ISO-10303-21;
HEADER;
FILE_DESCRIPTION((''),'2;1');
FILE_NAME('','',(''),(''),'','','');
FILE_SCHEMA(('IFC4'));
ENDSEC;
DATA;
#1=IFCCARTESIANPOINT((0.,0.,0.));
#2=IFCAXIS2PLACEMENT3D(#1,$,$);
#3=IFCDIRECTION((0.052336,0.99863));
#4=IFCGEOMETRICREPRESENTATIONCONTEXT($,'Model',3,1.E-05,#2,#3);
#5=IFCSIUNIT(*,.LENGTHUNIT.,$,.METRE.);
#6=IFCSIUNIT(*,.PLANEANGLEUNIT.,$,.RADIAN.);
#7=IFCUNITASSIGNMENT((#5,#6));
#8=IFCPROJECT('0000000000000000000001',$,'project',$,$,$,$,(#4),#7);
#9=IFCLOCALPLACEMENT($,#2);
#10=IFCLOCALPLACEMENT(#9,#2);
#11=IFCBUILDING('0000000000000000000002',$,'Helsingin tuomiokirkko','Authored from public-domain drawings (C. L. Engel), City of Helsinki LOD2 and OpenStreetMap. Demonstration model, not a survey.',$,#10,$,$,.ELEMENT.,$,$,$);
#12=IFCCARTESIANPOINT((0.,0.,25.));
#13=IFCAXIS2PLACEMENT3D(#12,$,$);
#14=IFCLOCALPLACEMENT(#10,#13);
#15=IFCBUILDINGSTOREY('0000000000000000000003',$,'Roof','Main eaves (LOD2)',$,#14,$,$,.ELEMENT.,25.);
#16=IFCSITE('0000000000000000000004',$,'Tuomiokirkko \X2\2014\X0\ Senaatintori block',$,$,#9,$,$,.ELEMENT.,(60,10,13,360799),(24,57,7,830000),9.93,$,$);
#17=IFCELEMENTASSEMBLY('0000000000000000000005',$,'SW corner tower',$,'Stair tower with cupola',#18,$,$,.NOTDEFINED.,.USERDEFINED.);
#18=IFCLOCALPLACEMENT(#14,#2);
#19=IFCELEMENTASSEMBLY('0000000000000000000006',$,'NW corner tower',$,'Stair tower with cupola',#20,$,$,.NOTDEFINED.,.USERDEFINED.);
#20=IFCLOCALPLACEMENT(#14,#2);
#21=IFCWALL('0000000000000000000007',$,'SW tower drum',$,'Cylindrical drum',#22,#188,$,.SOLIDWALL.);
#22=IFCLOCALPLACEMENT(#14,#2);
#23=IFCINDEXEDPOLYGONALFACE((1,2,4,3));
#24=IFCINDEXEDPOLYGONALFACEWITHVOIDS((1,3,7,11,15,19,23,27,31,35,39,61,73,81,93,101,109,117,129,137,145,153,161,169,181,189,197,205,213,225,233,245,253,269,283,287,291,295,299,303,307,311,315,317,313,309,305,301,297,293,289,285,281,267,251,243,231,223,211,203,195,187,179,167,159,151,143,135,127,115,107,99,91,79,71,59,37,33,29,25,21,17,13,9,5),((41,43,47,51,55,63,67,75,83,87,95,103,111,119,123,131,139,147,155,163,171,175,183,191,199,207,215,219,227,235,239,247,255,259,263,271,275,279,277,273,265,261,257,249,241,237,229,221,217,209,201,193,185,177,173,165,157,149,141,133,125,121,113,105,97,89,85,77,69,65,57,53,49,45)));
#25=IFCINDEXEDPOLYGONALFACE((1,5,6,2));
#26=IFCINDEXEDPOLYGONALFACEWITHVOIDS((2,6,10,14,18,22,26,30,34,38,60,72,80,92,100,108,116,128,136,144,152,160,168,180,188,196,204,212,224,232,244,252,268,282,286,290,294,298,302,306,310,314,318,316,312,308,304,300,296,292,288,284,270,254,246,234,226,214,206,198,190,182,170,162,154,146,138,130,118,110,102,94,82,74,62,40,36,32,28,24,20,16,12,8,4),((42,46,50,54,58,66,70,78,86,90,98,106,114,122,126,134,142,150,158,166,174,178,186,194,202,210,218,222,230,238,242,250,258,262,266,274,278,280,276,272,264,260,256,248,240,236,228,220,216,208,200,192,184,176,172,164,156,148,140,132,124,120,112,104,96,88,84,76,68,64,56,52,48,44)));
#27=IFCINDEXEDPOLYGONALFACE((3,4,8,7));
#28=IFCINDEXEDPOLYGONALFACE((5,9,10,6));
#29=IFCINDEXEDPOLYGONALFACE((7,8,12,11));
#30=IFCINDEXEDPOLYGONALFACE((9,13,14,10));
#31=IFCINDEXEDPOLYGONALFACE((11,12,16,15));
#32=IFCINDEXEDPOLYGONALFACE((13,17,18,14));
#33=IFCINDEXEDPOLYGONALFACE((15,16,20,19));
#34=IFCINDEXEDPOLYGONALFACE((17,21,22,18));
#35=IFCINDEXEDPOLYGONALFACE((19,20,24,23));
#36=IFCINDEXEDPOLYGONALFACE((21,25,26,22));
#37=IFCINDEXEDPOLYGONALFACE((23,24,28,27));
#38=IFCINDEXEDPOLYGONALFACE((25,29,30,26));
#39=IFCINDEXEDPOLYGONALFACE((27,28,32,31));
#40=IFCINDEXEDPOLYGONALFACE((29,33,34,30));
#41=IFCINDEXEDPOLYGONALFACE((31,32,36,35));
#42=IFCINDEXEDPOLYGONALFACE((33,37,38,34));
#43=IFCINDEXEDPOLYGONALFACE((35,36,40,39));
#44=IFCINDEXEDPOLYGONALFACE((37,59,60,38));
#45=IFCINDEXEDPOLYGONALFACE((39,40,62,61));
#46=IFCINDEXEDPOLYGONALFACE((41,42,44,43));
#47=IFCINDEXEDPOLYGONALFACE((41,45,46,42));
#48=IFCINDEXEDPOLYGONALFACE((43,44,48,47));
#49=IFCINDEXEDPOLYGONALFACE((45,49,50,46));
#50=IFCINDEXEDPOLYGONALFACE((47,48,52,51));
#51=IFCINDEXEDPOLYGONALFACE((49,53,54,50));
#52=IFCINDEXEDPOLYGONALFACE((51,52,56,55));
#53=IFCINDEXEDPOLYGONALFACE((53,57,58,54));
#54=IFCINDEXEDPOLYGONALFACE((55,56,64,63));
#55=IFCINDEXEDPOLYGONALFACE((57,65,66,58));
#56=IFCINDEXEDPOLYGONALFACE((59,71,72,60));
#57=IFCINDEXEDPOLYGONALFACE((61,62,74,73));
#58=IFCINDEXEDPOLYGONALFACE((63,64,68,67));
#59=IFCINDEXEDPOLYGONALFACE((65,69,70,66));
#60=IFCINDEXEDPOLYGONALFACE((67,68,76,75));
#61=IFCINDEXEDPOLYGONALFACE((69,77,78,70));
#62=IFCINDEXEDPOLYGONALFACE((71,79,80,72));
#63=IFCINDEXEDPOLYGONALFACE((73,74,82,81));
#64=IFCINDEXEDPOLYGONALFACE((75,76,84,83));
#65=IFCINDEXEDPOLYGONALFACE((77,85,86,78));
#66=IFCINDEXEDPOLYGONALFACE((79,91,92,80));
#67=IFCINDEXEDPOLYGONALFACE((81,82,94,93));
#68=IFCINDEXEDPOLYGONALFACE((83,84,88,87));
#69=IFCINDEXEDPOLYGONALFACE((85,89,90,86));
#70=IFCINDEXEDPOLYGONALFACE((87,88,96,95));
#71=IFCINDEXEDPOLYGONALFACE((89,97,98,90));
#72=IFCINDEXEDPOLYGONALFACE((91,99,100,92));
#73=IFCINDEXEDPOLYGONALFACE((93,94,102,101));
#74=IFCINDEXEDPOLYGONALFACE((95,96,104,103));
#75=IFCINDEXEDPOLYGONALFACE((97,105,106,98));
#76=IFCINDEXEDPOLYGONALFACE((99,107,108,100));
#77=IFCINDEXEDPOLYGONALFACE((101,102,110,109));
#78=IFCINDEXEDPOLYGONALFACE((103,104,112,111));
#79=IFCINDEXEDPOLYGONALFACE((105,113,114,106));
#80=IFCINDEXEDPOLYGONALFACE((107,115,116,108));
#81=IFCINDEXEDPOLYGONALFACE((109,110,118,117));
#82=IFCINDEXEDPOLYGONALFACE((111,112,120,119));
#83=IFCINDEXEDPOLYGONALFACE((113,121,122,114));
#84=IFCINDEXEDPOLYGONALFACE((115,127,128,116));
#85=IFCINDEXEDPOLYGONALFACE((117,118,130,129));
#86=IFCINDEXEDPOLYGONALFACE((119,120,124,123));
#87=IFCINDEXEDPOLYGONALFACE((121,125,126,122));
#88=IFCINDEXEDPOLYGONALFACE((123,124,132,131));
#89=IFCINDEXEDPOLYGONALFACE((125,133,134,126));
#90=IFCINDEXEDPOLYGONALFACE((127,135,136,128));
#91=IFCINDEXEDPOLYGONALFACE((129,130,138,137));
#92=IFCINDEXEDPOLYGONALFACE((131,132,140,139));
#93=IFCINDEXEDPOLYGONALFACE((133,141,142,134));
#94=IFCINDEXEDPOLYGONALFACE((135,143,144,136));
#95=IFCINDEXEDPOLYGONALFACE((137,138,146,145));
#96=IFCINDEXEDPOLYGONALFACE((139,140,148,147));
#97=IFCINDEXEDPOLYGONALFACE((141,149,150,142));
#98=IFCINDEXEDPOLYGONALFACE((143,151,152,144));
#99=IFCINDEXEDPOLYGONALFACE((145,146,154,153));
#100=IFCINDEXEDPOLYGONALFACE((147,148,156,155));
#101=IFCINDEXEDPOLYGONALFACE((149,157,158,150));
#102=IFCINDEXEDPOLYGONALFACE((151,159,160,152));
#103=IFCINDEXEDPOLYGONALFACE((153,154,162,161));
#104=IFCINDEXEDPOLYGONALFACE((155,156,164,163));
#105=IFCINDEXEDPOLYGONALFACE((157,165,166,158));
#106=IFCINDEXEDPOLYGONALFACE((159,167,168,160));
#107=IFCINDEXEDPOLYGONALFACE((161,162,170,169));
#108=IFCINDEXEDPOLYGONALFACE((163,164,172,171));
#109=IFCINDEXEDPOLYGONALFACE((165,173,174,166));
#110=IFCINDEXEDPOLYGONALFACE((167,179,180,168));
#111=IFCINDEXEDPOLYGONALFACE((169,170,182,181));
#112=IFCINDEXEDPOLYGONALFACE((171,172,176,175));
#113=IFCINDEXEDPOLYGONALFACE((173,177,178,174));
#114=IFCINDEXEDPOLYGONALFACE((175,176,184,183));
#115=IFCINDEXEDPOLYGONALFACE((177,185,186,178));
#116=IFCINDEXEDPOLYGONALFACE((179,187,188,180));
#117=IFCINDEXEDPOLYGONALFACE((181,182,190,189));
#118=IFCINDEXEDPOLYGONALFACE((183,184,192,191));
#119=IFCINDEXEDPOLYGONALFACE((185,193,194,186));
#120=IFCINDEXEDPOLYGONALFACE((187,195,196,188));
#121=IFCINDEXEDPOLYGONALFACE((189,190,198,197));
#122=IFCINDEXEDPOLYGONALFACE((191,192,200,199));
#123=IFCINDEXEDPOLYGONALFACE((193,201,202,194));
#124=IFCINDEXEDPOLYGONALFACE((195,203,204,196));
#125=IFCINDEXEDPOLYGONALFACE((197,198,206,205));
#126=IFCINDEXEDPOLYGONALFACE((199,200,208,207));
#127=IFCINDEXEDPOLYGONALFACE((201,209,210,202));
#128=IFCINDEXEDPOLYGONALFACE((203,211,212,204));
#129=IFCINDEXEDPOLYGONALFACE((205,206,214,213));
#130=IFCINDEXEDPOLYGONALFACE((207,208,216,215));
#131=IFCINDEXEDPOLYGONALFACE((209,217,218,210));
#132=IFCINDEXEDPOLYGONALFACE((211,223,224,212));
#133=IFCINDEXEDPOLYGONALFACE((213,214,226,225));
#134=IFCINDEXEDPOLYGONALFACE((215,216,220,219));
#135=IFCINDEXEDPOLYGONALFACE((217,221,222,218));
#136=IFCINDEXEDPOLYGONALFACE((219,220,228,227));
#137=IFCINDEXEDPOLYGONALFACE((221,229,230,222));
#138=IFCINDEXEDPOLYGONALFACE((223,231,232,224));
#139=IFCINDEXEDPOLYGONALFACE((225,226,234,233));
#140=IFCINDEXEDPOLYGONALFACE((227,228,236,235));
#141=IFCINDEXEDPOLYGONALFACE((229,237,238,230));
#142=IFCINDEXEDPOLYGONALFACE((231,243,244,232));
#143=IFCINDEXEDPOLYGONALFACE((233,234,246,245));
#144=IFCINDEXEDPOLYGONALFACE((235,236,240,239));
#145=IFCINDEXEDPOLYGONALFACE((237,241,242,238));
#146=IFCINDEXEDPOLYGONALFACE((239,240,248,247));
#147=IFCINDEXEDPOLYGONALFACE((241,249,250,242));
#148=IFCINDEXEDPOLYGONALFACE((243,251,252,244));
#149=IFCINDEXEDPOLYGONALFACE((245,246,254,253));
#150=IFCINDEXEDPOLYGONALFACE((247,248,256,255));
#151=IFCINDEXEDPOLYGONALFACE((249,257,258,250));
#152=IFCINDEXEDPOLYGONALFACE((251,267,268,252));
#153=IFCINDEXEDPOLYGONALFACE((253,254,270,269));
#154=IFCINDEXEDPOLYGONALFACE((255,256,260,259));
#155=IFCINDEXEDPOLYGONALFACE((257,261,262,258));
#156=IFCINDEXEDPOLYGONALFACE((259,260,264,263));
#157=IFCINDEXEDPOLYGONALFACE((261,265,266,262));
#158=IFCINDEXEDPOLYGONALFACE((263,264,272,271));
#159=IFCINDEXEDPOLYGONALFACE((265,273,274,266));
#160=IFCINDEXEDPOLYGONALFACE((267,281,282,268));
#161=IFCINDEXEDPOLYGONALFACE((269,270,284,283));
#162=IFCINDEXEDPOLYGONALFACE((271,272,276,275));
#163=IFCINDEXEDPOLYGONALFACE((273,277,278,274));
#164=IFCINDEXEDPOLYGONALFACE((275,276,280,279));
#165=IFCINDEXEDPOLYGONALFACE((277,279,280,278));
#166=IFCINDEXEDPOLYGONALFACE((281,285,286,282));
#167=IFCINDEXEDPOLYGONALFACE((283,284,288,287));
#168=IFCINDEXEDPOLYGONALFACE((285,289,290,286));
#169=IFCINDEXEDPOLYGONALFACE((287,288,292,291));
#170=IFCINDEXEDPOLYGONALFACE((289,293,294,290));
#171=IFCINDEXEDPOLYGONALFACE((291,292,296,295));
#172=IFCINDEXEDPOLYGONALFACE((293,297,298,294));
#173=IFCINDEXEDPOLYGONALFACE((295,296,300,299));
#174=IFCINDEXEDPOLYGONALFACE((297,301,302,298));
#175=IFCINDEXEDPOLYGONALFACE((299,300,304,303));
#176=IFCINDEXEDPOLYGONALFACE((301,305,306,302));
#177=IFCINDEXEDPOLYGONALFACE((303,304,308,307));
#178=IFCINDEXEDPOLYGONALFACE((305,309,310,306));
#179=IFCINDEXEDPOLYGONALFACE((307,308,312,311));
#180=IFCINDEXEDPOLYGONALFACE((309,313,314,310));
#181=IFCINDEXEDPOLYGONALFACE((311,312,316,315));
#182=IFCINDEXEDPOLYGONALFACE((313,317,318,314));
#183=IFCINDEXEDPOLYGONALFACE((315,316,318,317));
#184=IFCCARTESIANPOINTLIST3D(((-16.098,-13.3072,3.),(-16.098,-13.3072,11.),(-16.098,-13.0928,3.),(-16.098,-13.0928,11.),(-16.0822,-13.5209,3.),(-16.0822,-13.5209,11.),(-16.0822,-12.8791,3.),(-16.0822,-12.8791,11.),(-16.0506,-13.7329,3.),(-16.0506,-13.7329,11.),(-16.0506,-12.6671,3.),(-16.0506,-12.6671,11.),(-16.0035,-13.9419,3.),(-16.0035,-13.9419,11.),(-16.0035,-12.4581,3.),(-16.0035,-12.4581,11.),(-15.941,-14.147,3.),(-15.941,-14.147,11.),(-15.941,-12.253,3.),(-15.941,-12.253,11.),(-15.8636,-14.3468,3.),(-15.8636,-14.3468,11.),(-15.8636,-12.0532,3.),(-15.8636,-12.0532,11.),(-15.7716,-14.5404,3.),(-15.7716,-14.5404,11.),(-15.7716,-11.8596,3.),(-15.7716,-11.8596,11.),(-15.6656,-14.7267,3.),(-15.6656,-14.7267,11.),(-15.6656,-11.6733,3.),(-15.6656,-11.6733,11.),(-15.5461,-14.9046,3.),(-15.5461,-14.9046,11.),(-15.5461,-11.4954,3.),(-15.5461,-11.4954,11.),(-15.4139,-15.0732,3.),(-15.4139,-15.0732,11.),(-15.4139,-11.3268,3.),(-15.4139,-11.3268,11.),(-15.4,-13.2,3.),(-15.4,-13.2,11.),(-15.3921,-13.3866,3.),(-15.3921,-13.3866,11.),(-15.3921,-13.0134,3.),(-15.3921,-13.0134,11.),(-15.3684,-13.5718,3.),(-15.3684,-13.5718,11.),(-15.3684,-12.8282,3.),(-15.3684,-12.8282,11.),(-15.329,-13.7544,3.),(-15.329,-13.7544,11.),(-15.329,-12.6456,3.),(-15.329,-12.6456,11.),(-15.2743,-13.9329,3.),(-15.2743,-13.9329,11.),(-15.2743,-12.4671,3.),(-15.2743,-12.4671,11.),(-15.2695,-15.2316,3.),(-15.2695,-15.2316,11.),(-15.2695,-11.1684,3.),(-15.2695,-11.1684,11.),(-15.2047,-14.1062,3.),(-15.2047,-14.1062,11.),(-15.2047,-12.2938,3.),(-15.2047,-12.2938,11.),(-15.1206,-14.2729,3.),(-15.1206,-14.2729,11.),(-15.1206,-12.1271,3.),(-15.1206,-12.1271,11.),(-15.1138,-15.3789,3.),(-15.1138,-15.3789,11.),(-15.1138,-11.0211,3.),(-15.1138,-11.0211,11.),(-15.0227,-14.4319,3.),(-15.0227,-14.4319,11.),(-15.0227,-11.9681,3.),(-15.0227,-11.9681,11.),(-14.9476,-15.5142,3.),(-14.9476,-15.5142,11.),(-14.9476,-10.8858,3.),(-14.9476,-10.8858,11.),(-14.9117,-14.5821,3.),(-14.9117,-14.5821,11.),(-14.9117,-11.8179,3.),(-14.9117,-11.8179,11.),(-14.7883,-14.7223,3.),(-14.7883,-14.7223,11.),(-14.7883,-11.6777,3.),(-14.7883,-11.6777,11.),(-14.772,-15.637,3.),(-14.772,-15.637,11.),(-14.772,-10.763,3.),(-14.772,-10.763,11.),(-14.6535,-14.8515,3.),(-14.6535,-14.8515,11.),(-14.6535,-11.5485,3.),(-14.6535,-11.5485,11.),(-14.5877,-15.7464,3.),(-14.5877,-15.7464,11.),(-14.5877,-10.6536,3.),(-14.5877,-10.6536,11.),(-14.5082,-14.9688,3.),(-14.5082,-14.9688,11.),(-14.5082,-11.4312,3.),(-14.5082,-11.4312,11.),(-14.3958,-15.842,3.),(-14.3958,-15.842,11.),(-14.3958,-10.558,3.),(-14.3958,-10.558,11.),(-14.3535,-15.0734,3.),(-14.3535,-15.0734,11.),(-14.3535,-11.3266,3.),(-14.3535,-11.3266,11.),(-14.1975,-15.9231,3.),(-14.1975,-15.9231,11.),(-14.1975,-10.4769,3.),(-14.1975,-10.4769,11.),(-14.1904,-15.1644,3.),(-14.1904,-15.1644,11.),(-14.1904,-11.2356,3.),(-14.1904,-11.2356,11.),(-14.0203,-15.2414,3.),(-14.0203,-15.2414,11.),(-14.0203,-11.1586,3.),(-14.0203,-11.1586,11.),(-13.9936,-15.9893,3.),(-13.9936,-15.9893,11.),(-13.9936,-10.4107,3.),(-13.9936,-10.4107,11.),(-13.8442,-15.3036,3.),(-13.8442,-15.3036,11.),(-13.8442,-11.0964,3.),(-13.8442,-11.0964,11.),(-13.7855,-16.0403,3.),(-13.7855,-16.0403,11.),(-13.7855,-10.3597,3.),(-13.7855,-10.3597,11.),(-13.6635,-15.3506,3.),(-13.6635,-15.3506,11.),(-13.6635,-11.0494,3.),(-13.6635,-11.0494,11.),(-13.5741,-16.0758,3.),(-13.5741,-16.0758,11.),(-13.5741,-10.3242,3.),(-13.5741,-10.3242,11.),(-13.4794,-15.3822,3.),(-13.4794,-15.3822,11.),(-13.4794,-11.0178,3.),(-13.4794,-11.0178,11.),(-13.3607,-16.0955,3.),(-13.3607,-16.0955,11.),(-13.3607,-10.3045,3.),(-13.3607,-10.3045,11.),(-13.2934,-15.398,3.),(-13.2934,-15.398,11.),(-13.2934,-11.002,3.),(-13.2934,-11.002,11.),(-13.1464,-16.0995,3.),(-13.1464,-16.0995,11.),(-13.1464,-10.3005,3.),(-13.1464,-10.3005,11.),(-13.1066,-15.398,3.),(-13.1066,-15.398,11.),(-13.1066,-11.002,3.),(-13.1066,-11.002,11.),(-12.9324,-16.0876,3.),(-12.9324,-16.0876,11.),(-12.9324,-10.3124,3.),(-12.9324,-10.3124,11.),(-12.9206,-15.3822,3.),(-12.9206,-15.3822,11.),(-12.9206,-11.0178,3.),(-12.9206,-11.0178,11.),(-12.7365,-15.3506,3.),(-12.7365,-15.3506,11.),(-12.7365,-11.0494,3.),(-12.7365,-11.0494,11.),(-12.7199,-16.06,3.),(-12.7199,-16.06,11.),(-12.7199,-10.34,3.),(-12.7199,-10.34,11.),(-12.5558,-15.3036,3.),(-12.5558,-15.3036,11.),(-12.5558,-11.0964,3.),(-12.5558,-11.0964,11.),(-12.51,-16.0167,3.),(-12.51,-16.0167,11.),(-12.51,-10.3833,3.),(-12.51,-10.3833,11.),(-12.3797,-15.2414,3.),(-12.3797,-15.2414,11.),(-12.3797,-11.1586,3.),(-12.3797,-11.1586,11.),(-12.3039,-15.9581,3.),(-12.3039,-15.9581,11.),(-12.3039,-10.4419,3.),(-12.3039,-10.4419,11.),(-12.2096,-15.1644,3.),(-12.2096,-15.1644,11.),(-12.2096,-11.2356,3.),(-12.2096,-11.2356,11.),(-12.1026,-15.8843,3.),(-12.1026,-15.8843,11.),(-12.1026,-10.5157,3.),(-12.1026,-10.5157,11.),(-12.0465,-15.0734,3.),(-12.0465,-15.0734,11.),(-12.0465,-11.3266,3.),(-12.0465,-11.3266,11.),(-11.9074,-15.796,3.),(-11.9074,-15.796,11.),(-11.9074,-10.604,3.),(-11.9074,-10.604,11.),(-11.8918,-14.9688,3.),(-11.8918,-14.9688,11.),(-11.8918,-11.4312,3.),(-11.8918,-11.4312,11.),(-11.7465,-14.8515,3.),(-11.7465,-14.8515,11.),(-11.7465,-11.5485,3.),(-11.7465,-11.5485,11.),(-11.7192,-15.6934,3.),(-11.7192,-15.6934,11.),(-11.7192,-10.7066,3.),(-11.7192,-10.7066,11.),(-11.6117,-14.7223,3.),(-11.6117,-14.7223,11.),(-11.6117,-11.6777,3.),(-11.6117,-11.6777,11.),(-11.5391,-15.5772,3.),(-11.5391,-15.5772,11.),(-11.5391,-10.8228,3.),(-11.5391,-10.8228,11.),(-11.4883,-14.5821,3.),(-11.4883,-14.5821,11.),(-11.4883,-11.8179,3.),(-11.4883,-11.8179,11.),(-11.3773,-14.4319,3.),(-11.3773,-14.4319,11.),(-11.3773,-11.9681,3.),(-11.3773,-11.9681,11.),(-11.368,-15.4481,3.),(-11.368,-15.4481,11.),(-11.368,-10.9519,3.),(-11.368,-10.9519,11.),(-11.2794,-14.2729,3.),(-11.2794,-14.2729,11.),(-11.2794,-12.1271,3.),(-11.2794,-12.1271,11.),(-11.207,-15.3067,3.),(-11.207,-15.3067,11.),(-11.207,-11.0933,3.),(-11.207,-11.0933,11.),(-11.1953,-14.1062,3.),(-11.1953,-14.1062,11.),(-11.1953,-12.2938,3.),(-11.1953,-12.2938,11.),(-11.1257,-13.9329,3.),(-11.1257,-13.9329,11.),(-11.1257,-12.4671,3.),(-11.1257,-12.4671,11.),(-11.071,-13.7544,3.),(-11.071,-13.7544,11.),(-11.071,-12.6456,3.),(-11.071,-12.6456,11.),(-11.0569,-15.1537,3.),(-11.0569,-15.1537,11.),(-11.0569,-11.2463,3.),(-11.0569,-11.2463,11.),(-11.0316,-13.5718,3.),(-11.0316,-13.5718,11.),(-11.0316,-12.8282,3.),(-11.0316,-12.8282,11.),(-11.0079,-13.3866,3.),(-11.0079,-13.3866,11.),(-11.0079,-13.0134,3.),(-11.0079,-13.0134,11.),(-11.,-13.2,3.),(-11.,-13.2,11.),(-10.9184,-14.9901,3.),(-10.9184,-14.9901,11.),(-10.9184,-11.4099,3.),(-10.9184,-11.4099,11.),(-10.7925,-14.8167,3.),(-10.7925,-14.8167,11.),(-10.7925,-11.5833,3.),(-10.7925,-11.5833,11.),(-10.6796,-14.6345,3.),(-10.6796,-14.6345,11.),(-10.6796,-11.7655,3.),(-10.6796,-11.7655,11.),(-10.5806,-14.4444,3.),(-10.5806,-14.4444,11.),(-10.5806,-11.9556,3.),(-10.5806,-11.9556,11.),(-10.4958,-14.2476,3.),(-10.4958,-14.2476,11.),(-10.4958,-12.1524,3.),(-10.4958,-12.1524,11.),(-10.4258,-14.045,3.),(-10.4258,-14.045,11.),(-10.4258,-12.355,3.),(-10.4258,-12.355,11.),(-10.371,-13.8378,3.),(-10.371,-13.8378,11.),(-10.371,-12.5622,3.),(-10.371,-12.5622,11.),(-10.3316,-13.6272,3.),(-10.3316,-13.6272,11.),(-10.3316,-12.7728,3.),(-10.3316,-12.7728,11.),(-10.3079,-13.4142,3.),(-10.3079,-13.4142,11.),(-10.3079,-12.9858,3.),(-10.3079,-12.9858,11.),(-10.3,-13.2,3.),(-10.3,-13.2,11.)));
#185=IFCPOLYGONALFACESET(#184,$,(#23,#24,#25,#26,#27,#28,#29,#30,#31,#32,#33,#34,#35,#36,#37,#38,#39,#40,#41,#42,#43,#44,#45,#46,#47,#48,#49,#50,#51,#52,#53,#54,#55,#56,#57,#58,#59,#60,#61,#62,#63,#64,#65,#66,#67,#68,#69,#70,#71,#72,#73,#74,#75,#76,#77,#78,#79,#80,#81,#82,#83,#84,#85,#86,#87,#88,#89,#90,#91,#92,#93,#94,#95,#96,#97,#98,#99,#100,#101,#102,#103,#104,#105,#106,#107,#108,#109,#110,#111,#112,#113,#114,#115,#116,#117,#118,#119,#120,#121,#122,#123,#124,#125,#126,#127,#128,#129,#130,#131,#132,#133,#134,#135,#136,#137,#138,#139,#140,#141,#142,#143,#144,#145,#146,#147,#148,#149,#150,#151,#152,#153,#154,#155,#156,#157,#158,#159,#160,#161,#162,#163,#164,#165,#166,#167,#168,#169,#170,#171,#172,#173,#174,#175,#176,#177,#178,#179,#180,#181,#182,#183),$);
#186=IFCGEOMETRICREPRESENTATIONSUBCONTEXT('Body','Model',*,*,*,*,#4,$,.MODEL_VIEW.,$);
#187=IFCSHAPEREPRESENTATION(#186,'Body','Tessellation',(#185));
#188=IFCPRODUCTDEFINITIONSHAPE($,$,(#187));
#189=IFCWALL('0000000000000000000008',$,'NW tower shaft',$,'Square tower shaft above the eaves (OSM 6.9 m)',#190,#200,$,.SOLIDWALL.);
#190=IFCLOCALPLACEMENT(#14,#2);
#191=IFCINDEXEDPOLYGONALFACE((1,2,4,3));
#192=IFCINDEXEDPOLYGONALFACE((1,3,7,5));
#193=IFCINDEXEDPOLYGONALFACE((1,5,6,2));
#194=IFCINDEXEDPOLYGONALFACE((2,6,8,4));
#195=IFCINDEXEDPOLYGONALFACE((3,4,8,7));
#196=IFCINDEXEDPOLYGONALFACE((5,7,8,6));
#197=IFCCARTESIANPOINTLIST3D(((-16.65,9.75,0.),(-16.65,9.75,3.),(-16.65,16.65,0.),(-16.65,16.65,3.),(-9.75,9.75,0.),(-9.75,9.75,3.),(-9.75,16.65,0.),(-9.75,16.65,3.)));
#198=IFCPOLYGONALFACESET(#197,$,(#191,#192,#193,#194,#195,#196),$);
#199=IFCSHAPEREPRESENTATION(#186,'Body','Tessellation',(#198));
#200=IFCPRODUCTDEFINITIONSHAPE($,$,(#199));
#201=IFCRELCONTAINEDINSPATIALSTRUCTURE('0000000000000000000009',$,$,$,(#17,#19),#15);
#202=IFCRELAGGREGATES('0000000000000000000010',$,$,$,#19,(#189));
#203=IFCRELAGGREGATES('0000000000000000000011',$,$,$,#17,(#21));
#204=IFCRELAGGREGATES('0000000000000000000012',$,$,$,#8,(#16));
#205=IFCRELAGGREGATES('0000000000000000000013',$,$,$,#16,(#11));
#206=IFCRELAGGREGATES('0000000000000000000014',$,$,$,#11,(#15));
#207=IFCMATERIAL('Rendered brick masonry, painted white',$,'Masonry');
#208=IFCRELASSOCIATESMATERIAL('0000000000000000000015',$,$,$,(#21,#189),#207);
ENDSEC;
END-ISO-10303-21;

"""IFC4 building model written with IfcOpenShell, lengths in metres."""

from ifc_helpers import new_model, si_unit, direction, frame, origin, origin_2d_with_axis, place, context, subcontext, project, spatial, rectangle, hollow_circle, extrude, material, element, aggregate, save


model = new_model("IFC4")

# Units and contexts
model_context = context("Model", 3, precision=1e-05, world=origin(), true_north=direction((0.052336, 0.99863)))
body_context = subcontext(model_context, "Body", "Model", "MODEL_VIEW")
ifc_project = project(units=[si_unit("LENGTHUNIT", "METRE"), si_unit("PLANEANGLEUNIT", "RADIAN")], contexts=[model_context])

# Site, building, storey
site_placement = place(None, origin())
site = spatial("IfcSite", under=ifc_project, at=site_placement, Name="Tuomiokirkko — Senaatintori block", CompositionType="ELEMENT", RefLatitude=(60, 10, 13, 360799), RefLongitude=(24, 57, 7, 830000), RefElevation=9.93)
building_placement = place(site_placement, origin())
building = spatial("IfcBuilding", under=site, at=building_placement, Name="Helsingin tuomiokirkko", Description="Authored from public-domain drawings (C. L. Engel), City of Helsinki LOD2 and OpenStreetMap. Demonstration model, not a survey.", CompositionType="ELEMENT")
storey_placement = place(building_placement, frame((0.0, 0.0, 25.0)))
storey = spatial("IfcBuildingStorey", under=building, at=storey_placement, Name="Roof", Description="Main eaves (LOD2)", CompositionType="ELEMENT", Elevation=25.0)

# Element assemblies
assembly_1_placement = place(building_placement, origin())
assembly_1 = element("IfcElementAssembly", 1, at=assembly_1_placement, inside=storey, Name="SW corner tower", ObjectType="Stair tower with cupola", AssemblyPlace="NOTDEFINED", PredefinedType="USERDEFINED")
assembly_2_placement = place(building_placement, origin())
assembly_2 = element("IfcElementAssembly", 2, at=assembly_2_placement, inside=storey, Name="NW corner tower", ObjectType="Stair tower with cupola", AssemblyPlace="NOTDEFINED", PredefinedType="USERDEFINED")

# Shared definitions
ifc_material_1 = material(Name="Rendered brick masonry, painted white", Category="Masonry")

# Walls
wall_1_placement = place(building_placement, origin())
wall_1 = element("IfcWall", 3, at=wall_1_placement, material=ifc_material_1, Name="SW tower drum", ObjectType="Cylindrical drum", PredefinedType="SOLIDWALL", context=body_context, shape_type="SweptSolid", body=[
    extrude(hollow_circle(Radius=2.9, WallThickness=0.7, at=origin_2d_with_axis()), frame((-13.2, -13.2, 28.0)), (0.0, 0.0, 1.0), 8.0),
])
wall_2_placement = place(building_placement, origin())
wall_2 = element("IfcWall", 4, at=wall_2_placement, material=ifc_material_1, Name="NW tower shaft", ObjectType="Square tower shaft above the eaves (OSM 6.9 m)", PredefinedType="SOLIDWALL", context=body_context, shape_type="SweptSolid", body=[
    extrude(rectangle(XDim=6.9, YDim=6.9, at=origin_2d_with_axis()), frame((-13.2, 13.2, 25.0)), (0.0, 0.0, 1.0), 3.0),
])
aggregate(assembly_2, [wall_2])

aggregate(assembly_1, [wall_1])

save(model, "model.ifc")
